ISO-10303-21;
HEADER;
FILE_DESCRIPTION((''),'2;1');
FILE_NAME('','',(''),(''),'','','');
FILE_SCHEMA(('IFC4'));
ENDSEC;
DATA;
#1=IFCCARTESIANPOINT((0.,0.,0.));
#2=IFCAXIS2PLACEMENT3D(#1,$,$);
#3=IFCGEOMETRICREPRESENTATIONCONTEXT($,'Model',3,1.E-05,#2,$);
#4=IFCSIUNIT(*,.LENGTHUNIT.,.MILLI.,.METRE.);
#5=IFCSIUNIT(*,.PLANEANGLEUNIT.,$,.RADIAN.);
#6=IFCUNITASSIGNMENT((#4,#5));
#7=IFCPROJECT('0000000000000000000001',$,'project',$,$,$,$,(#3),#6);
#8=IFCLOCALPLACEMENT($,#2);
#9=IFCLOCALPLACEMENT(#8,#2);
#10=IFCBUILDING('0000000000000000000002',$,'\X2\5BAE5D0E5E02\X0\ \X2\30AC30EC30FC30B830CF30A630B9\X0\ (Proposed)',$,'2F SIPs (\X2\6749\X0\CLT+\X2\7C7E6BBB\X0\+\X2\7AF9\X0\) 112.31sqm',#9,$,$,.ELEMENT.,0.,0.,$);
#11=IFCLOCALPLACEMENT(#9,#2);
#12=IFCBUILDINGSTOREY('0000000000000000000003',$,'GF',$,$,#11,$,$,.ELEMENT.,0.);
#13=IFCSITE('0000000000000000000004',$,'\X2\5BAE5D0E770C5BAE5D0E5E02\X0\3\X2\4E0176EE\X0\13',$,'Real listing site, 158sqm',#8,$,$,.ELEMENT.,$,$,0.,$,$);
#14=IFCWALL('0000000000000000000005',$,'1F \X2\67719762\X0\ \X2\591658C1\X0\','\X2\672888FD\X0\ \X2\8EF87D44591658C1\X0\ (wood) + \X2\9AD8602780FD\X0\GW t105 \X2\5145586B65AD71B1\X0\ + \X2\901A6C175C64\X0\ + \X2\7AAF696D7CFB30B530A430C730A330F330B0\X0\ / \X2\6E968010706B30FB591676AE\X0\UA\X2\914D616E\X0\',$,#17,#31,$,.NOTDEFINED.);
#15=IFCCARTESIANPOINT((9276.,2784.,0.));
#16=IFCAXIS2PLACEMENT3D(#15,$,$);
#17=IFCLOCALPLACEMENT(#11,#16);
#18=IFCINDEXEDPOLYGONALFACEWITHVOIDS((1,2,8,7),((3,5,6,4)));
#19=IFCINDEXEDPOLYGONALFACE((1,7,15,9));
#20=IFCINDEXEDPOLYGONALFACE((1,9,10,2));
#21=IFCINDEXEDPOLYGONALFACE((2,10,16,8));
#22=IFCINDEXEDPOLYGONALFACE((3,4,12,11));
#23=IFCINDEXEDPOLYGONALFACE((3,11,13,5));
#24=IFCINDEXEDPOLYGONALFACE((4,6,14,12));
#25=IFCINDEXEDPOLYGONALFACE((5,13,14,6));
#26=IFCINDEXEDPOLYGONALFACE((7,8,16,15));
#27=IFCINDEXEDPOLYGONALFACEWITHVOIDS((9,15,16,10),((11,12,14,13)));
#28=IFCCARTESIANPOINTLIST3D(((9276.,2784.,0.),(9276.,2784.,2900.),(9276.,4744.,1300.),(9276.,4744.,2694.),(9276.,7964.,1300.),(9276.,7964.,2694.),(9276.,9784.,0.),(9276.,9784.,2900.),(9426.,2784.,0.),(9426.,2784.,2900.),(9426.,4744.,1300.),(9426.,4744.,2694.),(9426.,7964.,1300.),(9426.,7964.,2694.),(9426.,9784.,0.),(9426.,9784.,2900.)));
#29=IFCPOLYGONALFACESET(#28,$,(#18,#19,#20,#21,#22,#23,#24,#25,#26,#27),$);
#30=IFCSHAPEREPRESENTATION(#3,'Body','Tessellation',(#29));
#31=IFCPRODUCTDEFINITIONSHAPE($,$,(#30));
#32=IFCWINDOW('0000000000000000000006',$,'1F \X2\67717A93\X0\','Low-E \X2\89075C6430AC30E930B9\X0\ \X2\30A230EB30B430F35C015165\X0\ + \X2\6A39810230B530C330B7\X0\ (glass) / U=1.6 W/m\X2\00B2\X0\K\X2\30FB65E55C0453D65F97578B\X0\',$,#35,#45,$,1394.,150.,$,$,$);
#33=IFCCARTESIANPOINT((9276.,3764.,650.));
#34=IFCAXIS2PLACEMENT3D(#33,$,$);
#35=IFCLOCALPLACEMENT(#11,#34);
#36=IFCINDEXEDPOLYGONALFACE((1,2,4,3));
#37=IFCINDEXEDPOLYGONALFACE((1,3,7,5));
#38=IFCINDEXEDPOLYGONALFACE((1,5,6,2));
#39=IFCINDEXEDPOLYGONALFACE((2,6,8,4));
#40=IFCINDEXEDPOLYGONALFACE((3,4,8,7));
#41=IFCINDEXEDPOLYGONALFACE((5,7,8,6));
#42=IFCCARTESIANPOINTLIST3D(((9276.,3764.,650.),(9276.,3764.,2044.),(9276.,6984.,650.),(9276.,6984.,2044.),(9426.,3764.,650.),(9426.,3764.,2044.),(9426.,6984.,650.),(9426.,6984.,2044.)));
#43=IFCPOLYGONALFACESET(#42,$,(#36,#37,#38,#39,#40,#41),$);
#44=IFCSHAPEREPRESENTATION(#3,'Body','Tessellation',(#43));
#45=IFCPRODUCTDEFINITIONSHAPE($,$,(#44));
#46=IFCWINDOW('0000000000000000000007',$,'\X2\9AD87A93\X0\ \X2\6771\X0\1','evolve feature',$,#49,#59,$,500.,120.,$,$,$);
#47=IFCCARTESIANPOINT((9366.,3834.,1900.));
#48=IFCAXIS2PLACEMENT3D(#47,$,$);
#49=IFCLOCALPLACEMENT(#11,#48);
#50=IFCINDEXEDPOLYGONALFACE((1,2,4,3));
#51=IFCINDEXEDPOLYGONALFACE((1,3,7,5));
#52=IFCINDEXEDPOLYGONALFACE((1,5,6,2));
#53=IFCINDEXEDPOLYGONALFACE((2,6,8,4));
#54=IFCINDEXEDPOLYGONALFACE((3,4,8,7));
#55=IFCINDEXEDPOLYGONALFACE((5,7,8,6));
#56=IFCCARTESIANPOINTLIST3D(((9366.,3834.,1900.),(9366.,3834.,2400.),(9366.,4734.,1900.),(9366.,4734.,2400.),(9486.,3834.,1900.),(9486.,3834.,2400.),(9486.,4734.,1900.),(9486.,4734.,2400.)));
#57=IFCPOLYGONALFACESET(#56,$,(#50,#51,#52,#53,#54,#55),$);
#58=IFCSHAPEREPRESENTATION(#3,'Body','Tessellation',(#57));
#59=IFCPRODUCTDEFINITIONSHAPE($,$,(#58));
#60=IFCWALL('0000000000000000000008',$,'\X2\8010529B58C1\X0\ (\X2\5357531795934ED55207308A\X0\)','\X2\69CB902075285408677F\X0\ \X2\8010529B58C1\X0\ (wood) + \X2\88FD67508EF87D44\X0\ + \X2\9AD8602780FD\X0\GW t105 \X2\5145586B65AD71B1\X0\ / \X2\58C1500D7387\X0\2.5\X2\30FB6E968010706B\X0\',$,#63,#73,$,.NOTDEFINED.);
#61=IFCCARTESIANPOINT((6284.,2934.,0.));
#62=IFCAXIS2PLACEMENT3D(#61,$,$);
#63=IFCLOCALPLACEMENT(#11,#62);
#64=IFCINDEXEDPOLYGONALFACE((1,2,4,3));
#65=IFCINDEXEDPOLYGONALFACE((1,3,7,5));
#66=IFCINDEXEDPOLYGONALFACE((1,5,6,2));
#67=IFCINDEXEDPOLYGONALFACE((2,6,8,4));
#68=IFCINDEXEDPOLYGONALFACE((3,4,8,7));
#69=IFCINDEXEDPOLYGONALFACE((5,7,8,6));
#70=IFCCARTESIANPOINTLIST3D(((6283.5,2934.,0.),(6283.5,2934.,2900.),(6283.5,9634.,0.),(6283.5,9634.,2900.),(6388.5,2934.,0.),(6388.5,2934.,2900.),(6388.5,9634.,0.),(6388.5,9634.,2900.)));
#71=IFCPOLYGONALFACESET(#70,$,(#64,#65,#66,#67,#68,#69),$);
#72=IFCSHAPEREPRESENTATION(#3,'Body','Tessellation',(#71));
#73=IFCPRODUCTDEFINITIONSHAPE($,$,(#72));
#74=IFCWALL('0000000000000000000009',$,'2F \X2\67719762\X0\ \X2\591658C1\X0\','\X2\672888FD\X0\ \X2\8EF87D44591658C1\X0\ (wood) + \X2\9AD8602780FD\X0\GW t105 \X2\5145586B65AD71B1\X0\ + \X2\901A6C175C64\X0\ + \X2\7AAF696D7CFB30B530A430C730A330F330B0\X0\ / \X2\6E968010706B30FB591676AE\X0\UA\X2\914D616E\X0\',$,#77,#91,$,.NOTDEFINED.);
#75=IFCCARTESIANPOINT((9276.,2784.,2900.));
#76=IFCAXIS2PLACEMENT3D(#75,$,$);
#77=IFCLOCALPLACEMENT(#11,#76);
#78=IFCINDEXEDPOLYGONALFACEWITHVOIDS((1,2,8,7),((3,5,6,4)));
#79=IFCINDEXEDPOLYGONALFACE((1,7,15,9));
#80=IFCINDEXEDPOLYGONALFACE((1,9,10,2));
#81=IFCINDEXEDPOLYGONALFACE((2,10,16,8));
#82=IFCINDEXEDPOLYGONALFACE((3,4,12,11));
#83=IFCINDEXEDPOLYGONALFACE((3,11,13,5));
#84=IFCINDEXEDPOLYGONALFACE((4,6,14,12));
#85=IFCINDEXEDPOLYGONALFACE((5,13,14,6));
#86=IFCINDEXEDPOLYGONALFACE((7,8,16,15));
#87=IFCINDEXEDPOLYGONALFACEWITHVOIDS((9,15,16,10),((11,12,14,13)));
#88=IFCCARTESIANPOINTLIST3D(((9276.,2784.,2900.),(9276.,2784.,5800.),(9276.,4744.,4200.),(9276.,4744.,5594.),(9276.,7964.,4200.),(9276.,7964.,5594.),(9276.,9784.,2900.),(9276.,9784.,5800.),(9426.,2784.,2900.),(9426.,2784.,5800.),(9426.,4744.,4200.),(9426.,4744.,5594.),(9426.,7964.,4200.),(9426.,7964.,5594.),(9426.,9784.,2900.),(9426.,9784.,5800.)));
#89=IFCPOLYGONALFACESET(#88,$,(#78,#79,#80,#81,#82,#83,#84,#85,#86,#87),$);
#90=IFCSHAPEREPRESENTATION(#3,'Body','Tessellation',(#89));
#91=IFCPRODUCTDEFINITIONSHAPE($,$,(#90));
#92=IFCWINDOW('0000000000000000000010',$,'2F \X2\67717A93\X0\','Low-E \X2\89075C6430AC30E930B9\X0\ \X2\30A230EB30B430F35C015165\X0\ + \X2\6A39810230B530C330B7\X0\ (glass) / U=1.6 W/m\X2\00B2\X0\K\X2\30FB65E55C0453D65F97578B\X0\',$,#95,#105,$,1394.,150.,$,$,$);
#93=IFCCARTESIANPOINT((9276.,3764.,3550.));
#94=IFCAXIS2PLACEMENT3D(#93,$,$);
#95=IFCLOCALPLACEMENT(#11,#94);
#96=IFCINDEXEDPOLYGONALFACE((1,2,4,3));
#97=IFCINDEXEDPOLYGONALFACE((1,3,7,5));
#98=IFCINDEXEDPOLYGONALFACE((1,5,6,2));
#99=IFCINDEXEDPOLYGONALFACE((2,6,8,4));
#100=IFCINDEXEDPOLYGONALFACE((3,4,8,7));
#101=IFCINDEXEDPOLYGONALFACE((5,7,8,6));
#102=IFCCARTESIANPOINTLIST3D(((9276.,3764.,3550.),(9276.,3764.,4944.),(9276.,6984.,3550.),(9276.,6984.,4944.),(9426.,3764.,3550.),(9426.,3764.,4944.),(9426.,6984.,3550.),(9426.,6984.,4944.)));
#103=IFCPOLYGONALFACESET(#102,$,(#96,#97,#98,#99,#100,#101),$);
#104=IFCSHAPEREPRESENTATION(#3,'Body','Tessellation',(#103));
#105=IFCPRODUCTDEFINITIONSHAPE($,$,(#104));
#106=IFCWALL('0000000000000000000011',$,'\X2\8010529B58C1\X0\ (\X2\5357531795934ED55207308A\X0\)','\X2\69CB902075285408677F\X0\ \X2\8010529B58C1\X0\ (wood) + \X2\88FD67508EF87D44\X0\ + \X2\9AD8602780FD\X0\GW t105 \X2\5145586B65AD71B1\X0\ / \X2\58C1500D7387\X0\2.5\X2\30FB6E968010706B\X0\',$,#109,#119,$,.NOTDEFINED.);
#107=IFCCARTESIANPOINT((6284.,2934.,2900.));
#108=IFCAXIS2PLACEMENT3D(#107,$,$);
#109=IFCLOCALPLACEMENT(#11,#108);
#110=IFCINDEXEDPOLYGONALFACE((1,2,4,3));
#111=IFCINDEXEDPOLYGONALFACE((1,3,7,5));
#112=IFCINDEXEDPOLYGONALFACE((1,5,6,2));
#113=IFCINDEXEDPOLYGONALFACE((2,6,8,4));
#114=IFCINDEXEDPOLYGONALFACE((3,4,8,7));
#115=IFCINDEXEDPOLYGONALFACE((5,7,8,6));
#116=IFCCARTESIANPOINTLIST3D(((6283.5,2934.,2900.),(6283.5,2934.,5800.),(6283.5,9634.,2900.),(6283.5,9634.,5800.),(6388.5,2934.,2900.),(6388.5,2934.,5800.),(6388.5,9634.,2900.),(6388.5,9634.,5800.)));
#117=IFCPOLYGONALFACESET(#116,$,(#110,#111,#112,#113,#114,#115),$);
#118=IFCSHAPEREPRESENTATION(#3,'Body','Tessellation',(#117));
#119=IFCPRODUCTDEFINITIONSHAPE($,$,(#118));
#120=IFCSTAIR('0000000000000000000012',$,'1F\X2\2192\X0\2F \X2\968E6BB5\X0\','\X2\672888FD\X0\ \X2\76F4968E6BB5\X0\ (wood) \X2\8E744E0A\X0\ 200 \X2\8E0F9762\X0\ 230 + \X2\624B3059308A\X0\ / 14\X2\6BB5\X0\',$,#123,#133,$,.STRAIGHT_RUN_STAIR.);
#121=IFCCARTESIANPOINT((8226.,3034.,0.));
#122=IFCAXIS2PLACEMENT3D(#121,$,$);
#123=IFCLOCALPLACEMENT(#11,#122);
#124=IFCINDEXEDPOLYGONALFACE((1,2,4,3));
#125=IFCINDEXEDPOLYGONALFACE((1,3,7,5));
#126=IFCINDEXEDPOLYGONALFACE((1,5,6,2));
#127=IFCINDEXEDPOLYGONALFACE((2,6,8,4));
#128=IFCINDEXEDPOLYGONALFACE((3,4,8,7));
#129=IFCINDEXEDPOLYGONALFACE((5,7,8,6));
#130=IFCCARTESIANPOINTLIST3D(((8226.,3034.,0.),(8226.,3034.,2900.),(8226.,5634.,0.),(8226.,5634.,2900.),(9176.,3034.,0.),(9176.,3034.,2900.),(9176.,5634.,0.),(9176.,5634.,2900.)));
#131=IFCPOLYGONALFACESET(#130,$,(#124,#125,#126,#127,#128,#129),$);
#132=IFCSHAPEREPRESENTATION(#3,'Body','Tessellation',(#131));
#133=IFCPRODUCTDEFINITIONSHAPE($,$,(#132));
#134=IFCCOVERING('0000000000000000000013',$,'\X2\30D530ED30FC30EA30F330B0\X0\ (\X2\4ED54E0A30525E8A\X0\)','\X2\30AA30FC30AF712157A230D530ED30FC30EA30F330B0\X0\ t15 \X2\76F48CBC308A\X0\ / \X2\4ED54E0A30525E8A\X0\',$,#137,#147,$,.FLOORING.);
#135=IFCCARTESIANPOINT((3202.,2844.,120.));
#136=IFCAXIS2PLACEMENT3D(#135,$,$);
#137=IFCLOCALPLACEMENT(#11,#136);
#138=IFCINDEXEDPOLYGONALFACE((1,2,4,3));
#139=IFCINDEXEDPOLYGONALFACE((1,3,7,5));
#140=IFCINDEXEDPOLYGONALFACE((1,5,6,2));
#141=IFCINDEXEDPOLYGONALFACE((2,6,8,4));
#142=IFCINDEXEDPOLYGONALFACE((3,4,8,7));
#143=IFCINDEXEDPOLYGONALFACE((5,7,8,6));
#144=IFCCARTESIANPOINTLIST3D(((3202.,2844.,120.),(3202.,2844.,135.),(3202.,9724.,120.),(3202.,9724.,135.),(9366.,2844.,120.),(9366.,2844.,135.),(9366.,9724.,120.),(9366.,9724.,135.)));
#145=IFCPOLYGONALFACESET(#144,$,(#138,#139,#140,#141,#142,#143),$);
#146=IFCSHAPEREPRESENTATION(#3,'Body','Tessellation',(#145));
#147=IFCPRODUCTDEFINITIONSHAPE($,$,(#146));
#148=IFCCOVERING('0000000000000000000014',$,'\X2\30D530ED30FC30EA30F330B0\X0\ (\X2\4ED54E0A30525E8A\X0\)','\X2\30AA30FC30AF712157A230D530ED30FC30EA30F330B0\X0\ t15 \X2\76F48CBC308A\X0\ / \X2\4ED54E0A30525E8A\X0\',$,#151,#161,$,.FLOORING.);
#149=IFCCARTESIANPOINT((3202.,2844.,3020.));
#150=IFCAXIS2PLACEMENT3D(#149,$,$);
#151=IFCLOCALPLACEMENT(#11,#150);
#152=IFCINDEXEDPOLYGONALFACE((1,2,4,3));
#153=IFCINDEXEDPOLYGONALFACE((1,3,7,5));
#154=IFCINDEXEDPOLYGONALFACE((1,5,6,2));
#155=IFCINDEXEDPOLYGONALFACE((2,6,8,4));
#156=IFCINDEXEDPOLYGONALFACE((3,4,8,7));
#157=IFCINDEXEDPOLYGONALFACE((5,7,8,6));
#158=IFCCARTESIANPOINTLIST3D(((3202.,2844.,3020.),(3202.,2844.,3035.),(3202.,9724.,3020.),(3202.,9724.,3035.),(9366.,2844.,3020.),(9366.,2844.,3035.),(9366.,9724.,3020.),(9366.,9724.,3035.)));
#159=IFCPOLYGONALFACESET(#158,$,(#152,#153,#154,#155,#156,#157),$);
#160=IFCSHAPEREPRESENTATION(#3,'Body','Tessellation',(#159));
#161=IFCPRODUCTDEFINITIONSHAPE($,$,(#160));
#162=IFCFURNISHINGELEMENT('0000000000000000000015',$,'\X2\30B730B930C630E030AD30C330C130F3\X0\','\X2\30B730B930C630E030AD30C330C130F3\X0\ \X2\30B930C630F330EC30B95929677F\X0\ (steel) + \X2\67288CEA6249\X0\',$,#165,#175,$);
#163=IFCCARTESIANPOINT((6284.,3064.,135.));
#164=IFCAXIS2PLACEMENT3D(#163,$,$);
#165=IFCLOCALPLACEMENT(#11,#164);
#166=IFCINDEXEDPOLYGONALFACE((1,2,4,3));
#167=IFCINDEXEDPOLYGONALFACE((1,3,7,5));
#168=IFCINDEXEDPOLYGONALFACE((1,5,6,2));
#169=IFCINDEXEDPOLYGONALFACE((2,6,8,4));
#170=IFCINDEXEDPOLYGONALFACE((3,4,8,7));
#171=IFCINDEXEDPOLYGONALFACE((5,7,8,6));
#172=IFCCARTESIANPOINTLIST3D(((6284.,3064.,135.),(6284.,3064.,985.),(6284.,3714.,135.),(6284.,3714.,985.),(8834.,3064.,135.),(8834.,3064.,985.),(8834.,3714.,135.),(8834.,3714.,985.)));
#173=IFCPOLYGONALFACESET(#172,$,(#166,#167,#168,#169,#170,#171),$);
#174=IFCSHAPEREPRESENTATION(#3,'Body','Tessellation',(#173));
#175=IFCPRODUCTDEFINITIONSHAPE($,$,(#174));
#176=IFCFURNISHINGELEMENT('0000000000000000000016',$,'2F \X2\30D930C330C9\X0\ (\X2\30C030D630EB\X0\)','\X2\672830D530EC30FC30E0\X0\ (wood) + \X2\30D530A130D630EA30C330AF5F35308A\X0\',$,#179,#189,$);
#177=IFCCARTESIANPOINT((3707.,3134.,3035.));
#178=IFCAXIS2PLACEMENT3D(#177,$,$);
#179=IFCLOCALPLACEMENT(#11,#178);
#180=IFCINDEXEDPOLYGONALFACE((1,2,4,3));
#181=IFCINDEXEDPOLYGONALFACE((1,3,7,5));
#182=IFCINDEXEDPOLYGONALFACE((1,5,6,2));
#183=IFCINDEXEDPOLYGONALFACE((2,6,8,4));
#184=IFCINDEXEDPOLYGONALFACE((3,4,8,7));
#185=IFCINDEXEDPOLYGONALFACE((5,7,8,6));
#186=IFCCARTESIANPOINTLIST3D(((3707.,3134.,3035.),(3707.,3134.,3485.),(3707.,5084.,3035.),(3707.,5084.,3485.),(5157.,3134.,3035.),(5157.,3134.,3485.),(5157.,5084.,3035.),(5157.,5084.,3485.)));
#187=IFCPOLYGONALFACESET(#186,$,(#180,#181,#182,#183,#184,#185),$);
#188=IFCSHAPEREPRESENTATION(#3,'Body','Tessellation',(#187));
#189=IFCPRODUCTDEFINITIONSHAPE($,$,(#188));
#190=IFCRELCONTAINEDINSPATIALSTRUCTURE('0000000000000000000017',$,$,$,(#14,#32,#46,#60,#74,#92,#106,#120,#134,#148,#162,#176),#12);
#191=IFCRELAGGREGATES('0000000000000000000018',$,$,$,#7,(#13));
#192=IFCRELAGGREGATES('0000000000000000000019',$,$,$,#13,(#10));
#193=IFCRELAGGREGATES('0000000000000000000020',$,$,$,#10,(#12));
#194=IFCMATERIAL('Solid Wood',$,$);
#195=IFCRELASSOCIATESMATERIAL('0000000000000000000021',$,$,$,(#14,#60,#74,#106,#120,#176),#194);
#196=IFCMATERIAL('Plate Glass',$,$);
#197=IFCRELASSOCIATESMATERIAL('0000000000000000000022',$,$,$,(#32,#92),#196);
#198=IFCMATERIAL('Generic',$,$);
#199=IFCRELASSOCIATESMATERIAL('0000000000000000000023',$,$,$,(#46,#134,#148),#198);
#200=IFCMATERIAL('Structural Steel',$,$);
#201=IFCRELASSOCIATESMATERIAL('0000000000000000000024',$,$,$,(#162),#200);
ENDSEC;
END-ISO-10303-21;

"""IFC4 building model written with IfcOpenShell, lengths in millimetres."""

from ifc_helpers import new_model, si_unit, frame, frame_2d, origin, place, context, project, spatial, rectangle, extrude, material, element, fill, save


model = new_model("IFC4")

# Units and contexts
model_context = context("Model", 3, precision=1e-05, world=origin())
ifc_project = project(units=[si_unit("LENGTHUNIT", "METRE", prefix="MILLI"), si_unit("PLANEANGLEUNIT", "RADIAN")], contexts=[model_context])

# Site, building, storey
site_placement = place(None, origin())
site = spatial("IfcSite", under=ifc_project, at=site_placement, Name="宮崎県宮崎市3丁目13", ObjectType="Real listing site, 158sqm", CompositionType="ELEMENT", RefElevation=0.0)
building_placement = place(site_placement, origin())
building = spatial("IfcBuilding", under=site, at=building_placement, Name="宮崎市 ガレージハウス (Proposed)", ObjectType="2F SIPs (杉CLT+籾殻+竹) 112.31sqm", CompositionType="ELEMENT", ElevationOfRefHeight=0.0, ElevationOfTerrain=0.0)
storey_placement = place(building_placement, origin())
storey = spatial("IfcBuildingStorey", under=building, at=storey_placement, Name="GF", CompositionType="ELEMENT", Elevation=0.0)

# Shared definitions
ifc_material_1 = material(Name="Solid Wood")

# Wall, openings, windows
wall_1_placement = place(storey_placement, frame((9276.0, 2784.0, 0.0)))
wall_1 = element("IfcWall", 1, at=wall_1_placement, inside=storey, material=ifc_material_1, Name="1F 東面 外壁", Description="木製 軸組外壁 (wood) + 高性能GW t105 充填断熱 + 通気層 + 窯業系サイディング / 準耐火・外皮UA配慮", PredefinedType="NOTDEFINED", context=model_context, shape_type="SweptSolid", body=[
    extrude(rectangle(XDim=150.0, YDim=7000.0, at=frame_2d((75.0, 3500.0))), frame((9276.0, 2784.0, 0.0)), (0.0, 0.0, 1.0), 2900.0),
])
opening_1_placement = place(storey_placement, frame((9276.0, 3764.0, 650.0)))
opening_1 = element("IfcOpeningElement", 2, at=opening_1_placement, cuts=wall_1, PredefinedType="NOTDEFINED", context=model_context, shape_type="SweptSolid", body=[
    extrude(rectangle(XDim=150.0, YDim=3220.0, at=frame_2d((75.0, 1610.0))), frame((9276.0, 3764.0, 650.0)), (0.0, 0.0, 1.0), 1394.0),
])
opening_2_placement = place(storey_placement, frame((9366.0, 3834.0, 1900.0)))
opening_2 = element("IfcOpeningElement", 3, at=opening_2_placement, cuts=wall_1, PredefinedType="NOTDEFINED", context=model_context, shape_type="SweptSolid", body=[
    extrude(rectangle(XDim=120.0, YDim=900.0, at=frame_2d((60.0, 450.0))), frame((9366.0, 3834.0, 1900.0)), (0.0, 0.0, 1.0), 500.0),
])
ifc_material_2 = material(Name="Plate Glass")
window_1_placement = place(storey_placement, frame((9276.0, 3764.0, 650.0)))
window_1 = element("IfcWindow", 4, at=window_1_placement, inside=storey, material=ifc_material_2, Name="1F 東窓", Description="Low-E 複層ガラス アルゴン封入 + 樹脂サッシ (glass) / U=1.6 W/m²K・日射取得型", OverallHeight=1394.0, OverallWidth=150.0, context=model_context, shape_type="SweptSolid", body=[
    extrude(rectangle(XDim=150.0, YDim=3220.0, at=frame_2d((75.0, 1610.0))), frame((9276.0, 3764.0, 650.0)), (0.0, 0.0, 1.0), 1394.0),
])
fill(opening_1, window_1)
ifc_material_3 = material(Name="Generic")
window_2_placement = place(storey_placement, frame((9366.0, 3834.0, 1900.0)))
window_2 = element("IfcWindow", 5, at=window_2_placement, inside=storey, material=ifc_material_3, Name="高窓 東1", Description="evolve feature", OverallHeight=500.0, OverallWidth=120.0, context=model_context, shape_type="SweptSolid", body=[
    extrude(rectangle(XDim=120.0, YDim=900.0, at=frame_2d((60.0, 450.0))), frame((9366.0, 3834.0, 1900.0)), (0.0, 0.0, 1.0), 500.0),
])
fill(opening_2, window_2)

# Wall
wall_2_placement = place(storey_placement, frame((6284.0, 2934.0, 0.0)))
element("IfcWall", 6, at=wall_2_placement, inside=storey, material=ifc_material_1, Name="耐力壁 (南北間仕切り)", Description="構造用合板 耐力壁 (wood) + 製材軸組 + 高性能GW t105 充填断熱 / 壁倍率2.5・準耐火", PredefinedType="NOTDEFINED", context=model_context, shape_type="SweptSolid", body=[
    extrude(rectangle(XDim=105.0, YDim=6700.0, at=frame_2d((52.0, 3350.0))), frame((6284.0, 2934.0, 0.0)), (0.0, 0.0, 1.0), 2900.0),
])

# Wall, opening, window
wall_3_placement = place(storey_placement, frame((9276.0, 2784.0, 2900.0)))
wall_3 = element("IfcWall", 7, at=wall_3_placement, inside=storey, material=ifc_material_1, Name="2F 東面 外壁", Description="木製 軸組外壁 (wood) + 高性能GW t105 充填断熱 + 通気層 + 窯業系サイディング / 準耐火・外皮UA配慮", PredefinedType="NOTDEFINED", context=model_context, shape_type="SweptSolid", body=[
    extrude(rectangle(XDim=150.0, YDim=7000.0, at=frame_2d((75.0, 3500.0))), frame((9276.0, 2784.0, 2900.0)), (0.0, 0.0, 1.0), 2900.0),
])
opening_3_placement = place(storey_placement, frame((9276.0, 3764.0, 3550.0)))
opening_3 = element("IfcOpeningElement", 8, at=opening_3_placement, cuts=wall_3, PredefinedType="NOTDEFINED", context=model_context, shape_type="SweptSolid", body=[
    extrude(rectangle(XDim=150.0, YDim=3220.0, at=frame_2d((75.0, 1610.0))), frame((9276.0, 3764.0, 3550.0)), (0.0, 0.0, 1.0), 1394.0),
])
window_3_placement = place(storey_placement, frame((9276.0, 3764.0, 3550.0)))
window_3 = element("IfcWindow", 9, at=window_3_placement, inside=storey, material=ifc_material_2, Name="2F 東窓", Description="Low-E 複層ガラス アルゴン封入 + 樹脂サッシ (glass) / U=1.6 W/m²K・日射取得型", OverallHeight=1394.0, OverallWidth=150.0, context=model_context, shape_type="SweptSolid", body=[
    extrude(rectangle(XDim=150.0, YDim=3220.0, at=frame_2d((75.0, 1610.0))), frame((9276.0, 3764.0, 3550.0)), (0.0, 0.0, 1.0), 1394.0),
])
fill(opening_3, window_3)

# Wall
wall_4_placement = place(storey_placement, frame((6284.0, 2934.0, 2900.0)))
element("IfcWall", 10, at=wall_4_placement, inside=storey, material=ifc_material_1, Name="耐力壁 (南北間仕切り)", Description="構造用合板 耐力壁 (wood) + 製材軸組 + 高性能GW t105 充填断熱 / 壁倍率2.5・準耐火", PredefinedType="NOTDEFINED", context=model_context, shape_type="SweptSolid", body=[
    extrude(rectangle(XDim=105.0, YDim=6700.0, at=frame_2d((52.0, 3350.0))), frame((6284.0, 2934.0, 2900.0)), (0.0, 0.0, 1.0), 2900.0),
])

# Stair
stair_placement = place(storey_placement, frame((8226.0, 3034.0, 0.0)))
element("IfcStair", 11, at=stair_placement, inside=storey, material=ifc_material_1, Name="1F→2F 階段", Description="木製 直階段 (wood) 蹴上 200 踏面 230 + 手すり / 14段", PredefinedType="STRAIGHT_RUN_STAIR", context=model_context, shape_type="SweptSolid", body=[
    extrude(rectangle(XDim=950.0, YDim=2600.0, at=frame_2d((475.0, 1300.0))), frame((8226.0, 3034.0, 0.0)), (0.0, 0.0, 1.0), 2900.0),
])

# Coverings
covering_1_placement = place(storey_placement, frame((3202.0, 2844.0, 120.0)))
element("IfcCovering", 12, at=covering_1_placement, inside=storey, material=ifc_material_3, Name="フローリング (仕上げ床)", Description="オーク無垢フローリング t15 直貼り / 仕上げ床", PredefinedType="FLOORING", context=model_context, shape_type="SweptSolid", body=[
    extrude(rectangle(XDim=6164.0, YDim=6880.0, at=frame_2d((3082.0, 3440.0))), frame((3202.0, 2844.0, 120.0)), (0.0, 0.0, 1.0), 15.0),
])
covering_2_placement = place(storey_placement, frame((3202.0, 2844.0, 3020.0)))
element("IfcCovering", 13, at=covering_2_placement, inside=storey, material=ifc_material_3, Name="フローリング (仕上げ床)", Description="オーク無垢フローリング t15 直貼り / 仕上げ床", PredefinedType="FLOORING", context=model_context, shape_type="SweptSolid", body=[
    extrude(rectangle(XDim=6164.0, YDim=6880.0, at=frame_2d((3082.0, 3440.0))), frame((3202.0, 2844.0, 3020.0)), (0.0, 0.0, 1.0), 15.0),
])

# Furnishing elements
ifc_material_4 = material(Name="Structural Steel")
furnishing_1_placement = place(storey_placement, frame((6284.0, 3064.0, 135.0)))
element("IfcFurnishingElement", 14, at=furnishing_1_placement, inside=storey, material=ifc_material_4, Name="システムキッチン", Description="システムキッチン ステンレス天板 (steel) + 木質扉", context=model_context, shape_type="SweptSolid", body=[
    extrude(rectangle(XDim=2550.0, YDim=650.0, at=frame_2d((1275.0, 325.0))), frame((6284.0, 3064.0, 135.0)), (0.0, 0.0, 1.0), 850.0),
])
furnishing_2_placement = place(storey_placement, frame((3707.0, 3134.0, 3035.0)))
element("IfcFurnishingElement", 15, at=furnishing_2_placement, inside=storey, material=ifc_material_1, Name="2F ベッド (ダブル)", Description="木フレーム (wood) + ファブリック張り", context=model_context, shape_type="SweptSolid", body=[
    extrude(rectangle(XDim=1450.0, YDim=1950.0, at=frame_2d((725.0, 975.0))), frame((3707.0, 3134.0, 3035.0)), (0.0, 0.0, 1.0), 450.0),
])

save(model, "model.ifc")
